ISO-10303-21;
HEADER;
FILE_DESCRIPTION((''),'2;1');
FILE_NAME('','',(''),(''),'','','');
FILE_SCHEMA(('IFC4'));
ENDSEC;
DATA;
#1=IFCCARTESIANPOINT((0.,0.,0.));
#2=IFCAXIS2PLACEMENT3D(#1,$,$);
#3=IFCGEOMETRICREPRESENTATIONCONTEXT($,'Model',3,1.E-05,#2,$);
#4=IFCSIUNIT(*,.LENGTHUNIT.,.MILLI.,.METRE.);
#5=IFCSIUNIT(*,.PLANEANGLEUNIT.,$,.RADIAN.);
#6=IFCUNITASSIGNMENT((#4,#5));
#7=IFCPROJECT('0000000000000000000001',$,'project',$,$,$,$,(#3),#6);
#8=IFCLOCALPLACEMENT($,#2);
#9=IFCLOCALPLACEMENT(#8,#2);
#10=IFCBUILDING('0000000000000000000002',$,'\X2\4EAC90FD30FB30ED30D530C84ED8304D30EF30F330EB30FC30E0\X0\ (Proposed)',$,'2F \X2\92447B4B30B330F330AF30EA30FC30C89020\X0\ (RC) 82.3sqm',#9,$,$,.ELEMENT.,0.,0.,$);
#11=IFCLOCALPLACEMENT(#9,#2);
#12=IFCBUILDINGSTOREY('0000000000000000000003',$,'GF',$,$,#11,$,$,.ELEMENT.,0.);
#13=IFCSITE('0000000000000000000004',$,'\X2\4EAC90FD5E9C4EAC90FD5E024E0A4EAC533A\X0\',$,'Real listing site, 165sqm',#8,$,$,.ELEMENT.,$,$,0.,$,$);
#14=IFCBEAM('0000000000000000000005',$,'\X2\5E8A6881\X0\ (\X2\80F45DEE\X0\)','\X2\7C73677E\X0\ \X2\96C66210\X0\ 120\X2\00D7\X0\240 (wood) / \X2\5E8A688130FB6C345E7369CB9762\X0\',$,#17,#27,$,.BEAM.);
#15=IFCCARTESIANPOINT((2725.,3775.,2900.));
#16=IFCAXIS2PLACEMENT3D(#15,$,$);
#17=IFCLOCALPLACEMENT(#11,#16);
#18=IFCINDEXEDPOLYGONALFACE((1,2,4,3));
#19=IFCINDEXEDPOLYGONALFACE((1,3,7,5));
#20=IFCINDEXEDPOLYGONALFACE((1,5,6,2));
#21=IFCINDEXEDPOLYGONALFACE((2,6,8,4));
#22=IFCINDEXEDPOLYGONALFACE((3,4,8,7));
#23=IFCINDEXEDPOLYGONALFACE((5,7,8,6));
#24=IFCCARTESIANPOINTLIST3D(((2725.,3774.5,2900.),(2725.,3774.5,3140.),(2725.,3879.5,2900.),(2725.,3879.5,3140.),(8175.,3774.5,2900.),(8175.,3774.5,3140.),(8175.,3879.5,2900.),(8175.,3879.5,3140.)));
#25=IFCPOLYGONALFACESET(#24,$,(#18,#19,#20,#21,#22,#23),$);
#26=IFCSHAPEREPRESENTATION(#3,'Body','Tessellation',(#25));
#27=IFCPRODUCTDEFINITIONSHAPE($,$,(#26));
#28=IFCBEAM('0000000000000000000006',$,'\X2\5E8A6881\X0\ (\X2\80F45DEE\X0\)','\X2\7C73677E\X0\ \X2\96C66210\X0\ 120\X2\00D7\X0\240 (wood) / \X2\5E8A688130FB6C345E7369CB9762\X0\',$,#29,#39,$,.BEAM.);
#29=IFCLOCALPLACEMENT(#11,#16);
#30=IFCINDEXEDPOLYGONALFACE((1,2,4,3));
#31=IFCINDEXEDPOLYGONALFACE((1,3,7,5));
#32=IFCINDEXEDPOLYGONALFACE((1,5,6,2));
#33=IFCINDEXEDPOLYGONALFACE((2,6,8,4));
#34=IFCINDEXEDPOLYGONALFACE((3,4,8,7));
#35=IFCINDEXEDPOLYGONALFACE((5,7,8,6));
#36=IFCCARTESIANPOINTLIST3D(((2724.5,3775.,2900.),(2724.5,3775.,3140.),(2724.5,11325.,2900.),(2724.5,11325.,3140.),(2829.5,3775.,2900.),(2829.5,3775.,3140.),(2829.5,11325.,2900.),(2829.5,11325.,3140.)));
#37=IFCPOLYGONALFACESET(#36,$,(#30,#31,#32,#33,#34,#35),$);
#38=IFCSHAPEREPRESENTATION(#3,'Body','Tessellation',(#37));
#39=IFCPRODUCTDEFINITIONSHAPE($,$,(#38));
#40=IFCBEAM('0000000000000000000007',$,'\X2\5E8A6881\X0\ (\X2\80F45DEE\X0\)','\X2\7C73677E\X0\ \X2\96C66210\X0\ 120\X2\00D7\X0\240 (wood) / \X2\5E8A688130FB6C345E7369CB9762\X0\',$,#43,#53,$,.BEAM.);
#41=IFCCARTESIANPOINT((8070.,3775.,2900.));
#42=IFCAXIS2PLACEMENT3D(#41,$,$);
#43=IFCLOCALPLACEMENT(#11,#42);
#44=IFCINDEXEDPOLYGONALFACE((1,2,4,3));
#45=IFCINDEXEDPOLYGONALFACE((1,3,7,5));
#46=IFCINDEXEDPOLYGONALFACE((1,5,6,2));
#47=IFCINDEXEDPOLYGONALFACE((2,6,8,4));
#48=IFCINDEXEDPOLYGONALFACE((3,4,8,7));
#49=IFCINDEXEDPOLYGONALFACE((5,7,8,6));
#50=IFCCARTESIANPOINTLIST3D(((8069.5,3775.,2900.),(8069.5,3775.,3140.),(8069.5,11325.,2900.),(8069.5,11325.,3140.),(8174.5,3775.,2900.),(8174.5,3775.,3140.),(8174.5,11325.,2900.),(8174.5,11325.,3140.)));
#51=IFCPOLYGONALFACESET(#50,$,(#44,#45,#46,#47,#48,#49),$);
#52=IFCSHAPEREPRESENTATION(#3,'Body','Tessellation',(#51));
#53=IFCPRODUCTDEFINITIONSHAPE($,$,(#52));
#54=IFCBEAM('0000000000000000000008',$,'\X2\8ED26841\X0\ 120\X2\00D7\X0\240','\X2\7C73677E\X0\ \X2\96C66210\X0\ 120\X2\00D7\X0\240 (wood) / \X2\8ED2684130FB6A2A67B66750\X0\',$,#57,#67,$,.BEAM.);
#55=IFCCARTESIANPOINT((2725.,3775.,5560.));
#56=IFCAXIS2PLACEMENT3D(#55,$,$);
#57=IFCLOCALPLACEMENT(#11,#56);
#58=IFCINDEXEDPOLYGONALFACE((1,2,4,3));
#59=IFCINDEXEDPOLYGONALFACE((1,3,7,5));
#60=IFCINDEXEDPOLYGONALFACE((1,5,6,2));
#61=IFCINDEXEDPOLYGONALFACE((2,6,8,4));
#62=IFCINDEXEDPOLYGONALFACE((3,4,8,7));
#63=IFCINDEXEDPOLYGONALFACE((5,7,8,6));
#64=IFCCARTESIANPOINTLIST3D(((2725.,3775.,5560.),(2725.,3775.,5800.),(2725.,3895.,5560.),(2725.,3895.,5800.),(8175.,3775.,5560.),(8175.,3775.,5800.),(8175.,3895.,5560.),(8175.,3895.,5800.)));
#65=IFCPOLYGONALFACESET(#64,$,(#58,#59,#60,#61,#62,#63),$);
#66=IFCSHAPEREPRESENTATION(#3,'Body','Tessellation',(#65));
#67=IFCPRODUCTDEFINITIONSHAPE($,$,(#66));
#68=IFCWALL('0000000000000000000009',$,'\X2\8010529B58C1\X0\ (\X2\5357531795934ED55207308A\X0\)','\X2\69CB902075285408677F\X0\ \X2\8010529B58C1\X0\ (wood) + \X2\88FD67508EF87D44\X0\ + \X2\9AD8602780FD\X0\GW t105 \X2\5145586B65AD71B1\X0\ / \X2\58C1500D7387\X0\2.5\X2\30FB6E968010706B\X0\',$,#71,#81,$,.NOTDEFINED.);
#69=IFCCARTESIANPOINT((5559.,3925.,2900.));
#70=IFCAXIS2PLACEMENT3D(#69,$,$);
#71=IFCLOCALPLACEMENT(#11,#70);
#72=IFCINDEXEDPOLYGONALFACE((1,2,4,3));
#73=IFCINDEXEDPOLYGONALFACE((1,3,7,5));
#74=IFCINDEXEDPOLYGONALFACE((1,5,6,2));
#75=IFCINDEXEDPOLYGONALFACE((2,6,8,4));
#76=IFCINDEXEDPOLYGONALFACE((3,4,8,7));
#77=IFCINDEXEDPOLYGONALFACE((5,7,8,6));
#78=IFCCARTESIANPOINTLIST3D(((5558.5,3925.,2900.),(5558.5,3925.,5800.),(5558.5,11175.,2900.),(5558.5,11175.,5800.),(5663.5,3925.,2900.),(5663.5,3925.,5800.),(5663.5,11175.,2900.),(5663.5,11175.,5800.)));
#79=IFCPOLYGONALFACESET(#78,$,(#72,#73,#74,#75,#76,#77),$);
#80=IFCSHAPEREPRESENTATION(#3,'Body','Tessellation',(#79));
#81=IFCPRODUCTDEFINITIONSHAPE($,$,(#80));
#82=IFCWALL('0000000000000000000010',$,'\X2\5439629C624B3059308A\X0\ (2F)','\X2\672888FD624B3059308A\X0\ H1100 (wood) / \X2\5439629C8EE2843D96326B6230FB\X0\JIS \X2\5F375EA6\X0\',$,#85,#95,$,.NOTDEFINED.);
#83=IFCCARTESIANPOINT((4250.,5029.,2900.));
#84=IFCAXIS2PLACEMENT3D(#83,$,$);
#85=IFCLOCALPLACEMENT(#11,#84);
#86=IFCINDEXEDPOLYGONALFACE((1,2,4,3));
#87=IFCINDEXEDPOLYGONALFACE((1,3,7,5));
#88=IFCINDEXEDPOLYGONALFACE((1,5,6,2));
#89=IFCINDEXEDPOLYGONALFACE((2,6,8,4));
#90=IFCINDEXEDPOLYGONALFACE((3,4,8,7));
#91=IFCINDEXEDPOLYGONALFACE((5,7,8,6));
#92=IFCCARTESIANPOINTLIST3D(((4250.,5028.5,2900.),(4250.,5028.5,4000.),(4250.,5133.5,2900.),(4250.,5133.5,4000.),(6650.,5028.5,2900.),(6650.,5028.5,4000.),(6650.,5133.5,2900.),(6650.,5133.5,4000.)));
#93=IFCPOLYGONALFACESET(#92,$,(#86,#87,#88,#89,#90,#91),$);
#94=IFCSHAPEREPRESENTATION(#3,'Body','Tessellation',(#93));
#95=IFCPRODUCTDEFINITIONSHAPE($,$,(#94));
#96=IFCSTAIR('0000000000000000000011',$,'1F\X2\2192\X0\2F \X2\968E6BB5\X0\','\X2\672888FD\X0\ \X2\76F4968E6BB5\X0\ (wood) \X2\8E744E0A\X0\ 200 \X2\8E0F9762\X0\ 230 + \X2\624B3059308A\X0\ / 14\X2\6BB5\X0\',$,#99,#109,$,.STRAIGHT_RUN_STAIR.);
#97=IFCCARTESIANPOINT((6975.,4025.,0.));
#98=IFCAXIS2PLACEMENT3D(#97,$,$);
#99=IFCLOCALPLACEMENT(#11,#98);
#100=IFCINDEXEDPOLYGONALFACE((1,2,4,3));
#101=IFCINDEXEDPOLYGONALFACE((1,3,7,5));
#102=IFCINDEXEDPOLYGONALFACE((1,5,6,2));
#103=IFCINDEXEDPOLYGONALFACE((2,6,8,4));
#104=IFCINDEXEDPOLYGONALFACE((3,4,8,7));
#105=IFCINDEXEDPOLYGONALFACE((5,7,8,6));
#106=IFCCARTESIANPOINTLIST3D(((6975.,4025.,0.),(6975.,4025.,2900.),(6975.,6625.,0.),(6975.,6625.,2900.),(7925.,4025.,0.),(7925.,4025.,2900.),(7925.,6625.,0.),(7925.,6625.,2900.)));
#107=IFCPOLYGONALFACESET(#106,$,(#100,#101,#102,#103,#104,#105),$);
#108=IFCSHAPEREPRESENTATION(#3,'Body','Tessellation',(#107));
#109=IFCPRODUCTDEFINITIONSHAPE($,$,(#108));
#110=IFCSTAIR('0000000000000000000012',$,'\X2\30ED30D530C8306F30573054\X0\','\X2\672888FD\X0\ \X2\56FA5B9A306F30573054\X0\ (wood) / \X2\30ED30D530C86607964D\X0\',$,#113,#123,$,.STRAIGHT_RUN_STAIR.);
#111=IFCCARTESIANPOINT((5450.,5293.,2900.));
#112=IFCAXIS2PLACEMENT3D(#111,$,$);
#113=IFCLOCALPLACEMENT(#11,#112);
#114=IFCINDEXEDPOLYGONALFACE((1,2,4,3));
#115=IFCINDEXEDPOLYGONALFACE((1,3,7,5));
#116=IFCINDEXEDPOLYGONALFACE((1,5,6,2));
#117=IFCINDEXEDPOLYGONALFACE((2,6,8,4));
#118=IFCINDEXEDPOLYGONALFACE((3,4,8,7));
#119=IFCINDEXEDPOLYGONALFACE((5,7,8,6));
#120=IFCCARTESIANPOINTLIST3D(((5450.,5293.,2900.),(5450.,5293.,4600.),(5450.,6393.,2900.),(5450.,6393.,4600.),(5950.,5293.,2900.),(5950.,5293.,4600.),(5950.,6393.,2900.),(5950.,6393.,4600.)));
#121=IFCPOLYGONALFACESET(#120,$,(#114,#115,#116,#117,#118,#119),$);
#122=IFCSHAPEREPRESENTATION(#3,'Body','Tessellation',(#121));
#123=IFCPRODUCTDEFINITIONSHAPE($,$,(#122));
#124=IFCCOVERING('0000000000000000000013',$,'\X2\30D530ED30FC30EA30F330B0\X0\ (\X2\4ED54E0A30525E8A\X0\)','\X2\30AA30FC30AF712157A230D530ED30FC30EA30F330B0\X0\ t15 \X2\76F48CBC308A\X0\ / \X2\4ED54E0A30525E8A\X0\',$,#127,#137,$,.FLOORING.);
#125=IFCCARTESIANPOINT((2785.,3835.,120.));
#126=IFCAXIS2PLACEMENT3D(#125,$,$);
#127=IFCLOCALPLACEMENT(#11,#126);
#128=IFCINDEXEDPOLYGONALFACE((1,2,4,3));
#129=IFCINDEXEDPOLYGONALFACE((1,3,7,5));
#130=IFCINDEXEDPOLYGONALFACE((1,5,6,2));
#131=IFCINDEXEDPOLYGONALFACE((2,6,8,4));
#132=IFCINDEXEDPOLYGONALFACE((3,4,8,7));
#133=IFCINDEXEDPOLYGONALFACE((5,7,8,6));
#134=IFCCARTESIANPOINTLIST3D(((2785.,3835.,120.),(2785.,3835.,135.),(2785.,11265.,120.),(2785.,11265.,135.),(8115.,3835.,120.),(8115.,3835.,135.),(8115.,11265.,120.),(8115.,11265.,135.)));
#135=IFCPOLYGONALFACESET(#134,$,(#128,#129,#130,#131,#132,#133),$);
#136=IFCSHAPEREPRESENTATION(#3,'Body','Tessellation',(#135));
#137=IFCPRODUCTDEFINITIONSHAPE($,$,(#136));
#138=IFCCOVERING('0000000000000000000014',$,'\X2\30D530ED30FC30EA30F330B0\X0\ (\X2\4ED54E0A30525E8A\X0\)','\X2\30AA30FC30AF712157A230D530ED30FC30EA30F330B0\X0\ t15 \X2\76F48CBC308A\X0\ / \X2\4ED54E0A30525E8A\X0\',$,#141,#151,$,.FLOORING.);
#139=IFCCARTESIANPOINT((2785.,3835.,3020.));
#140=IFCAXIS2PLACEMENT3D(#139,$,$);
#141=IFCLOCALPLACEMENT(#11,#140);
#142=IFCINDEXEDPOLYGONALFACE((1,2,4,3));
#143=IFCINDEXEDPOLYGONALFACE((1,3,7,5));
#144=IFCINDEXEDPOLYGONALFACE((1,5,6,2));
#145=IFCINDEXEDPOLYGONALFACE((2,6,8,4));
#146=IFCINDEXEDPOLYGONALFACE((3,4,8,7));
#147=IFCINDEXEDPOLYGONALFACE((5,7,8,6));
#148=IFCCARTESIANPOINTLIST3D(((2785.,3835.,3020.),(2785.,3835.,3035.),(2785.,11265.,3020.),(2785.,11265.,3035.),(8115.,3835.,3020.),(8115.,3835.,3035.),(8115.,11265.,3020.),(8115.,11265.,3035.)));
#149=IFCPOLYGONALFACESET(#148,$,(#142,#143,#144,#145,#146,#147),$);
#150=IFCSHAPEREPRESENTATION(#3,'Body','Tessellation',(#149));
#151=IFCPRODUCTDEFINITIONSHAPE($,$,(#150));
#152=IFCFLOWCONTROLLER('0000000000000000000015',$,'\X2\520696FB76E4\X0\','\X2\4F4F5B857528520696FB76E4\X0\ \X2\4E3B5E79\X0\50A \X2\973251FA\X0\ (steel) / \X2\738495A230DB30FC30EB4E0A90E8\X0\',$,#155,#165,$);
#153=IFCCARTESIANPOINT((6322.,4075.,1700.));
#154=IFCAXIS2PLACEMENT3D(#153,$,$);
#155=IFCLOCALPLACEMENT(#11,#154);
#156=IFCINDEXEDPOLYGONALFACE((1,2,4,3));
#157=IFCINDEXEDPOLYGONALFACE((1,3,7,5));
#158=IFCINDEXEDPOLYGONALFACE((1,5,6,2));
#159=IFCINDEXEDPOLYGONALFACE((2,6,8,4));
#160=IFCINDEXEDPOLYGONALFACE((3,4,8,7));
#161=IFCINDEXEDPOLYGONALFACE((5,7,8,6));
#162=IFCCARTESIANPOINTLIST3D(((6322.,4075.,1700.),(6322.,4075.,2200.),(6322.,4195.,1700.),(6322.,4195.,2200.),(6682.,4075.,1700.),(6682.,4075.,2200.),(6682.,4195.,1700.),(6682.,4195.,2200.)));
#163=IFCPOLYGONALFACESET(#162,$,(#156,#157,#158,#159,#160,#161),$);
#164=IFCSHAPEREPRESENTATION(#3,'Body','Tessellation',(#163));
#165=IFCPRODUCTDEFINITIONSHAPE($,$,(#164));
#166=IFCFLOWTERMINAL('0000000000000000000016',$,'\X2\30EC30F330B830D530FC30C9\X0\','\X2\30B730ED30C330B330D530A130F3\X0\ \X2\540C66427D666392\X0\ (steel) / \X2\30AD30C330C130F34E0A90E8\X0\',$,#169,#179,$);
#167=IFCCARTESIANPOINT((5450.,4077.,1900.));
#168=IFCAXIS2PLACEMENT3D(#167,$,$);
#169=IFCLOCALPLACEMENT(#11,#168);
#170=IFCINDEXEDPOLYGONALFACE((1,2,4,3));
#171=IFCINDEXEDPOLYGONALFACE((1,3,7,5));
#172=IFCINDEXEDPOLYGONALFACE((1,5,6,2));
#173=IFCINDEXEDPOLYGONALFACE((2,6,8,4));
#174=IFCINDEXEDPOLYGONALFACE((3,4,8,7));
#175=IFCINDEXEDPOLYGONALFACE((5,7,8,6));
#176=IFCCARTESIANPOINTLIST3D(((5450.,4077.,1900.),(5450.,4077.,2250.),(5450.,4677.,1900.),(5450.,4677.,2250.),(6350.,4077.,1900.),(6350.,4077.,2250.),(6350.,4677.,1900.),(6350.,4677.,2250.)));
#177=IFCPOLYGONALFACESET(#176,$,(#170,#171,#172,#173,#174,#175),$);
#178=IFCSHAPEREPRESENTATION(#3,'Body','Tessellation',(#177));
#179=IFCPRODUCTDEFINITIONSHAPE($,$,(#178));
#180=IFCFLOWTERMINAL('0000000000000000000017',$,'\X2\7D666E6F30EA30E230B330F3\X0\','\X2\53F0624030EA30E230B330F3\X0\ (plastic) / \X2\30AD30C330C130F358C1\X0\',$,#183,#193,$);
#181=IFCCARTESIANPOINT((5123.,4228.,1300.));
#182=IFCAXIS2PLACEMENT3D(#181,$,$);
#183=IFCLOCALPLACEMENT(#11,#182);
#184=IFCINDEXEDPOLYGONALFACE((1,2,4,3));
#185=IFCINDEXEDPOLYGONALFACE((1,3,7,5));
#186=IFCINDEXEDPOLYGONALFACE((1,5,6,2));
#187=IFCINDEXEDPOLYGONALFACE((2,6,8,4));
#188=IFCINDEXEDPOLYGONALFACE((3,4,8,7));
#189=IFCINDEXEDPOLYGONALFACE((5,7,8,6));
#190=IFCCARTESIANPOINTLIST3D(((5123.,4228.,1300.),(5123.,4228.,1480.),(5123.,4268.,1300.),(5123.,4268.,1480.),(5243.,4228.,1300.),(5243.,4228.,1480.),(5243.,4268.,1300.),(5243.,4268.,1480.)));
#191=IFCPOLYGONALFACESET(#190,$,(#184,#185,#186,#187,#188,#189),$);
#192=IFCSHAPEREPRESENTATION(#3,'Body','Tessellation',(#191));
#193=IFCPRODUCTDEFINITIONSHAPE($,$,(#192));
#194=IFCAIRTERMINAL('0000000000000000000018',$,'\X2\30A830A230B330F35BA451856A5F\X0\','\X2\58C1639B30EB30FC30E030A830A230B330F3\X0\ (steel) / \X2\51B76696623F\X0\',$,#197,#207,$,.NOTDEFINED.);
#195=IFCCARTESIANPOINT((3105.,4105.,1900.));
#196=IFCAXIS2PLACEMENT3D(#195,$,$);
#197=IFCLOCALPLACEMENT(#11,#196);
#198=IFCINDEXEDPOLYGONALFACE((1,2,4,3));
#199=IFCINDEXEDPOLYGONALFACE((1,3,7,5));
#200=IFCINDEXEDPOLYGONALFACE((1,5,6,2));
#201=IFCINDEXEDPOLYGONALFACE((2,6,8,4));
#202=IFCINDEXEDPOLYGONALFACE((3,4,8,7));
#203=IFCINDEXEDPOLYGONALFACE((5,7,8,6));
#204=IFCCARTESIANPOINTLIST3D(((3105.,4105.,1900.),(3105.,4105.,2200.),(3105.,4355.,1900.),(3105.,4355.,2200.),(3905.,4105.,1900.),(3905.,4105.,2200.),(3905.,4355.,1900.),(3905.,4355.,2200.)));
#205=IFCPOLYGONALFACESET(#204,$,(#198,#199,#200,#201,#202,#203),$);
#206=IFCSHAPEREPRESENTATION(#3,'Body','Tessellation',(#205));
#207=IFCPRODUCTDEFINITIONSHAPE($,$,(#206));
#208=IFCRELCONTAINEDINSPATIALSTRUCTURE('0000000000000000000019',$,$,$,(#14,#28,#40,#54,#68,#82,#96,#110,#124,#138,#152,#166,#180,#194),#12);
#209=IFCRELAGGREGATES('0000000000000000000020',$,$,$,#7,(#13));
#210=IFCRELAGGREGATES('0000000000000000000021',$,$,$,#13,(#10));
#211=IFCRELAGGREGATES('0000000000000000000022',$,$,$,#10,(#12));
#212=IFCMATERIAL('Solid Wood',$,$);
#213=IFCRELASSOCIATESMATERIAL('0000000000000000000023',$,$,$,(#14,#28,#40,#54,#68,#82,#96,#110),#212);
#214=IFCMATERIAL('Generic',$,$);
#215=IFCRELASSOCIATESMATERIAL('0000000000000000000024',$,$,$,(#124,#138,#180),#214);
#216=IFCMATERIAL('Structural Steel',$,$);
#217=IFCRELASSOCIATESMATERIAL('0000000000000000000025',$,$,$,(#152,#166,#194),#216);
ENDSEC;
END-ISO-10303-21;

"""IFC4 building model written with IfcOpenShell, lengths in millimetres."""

from ifc_helpers import new_model, si_unit, frame, frame_2d, origin, place, context, project, spatial, rectangle, extrude, material, element, save


model = new_model("IFC4")

# Units and contexts
model_context = context("Model", 3, precision=1e-05, world=origin())
ifc_project = project(units=[si_unit("LENGTHUNIT", "METRE", prefix="MILLI"), si_unit("PLANEANGLEUNIT", "RADIAN")], contexts=[model_context])

# Site, building, storey
site_placement = place(None, origin())
site = spatial("IfcSite", under=ifc_project, at=site_placement, Name="京都府京都市上京区", ObjectType="Real listing site, 165sqm", CompositionType="ELEMENT", RefElevation=0.0)
building_placement = place(site_placement, origin())
building = spatial("IfcBuilding", under=site, at=building_placement, Name="京都・ロフト付きワンルーム (Proposed)", ObjectType="2F 鉄筋コンクリート造 (RC) 82.3sqm", CompositionType="ELEMENT", ElevationOfRefHeight=0.0, ElevationOfTerrain=0.0)
storey_placement = place(building_placement, origin())
storey = spatial("IfcBuildingStorey", under=building, at=storey_placement, Name="GF", CompositionType="ELEMENT", Elevation=0.0)

# Beams
ifc_material_1 = material(Name="Solid Wood")
beam_1_placement = place(storey_placement, frame((2725.0, 3775.0, 2900.0)))
element("IfcBeam", 1, at=beam_1_placement, inside=storey, material=ifc_material_1, Name="床梁 (胴差)", Description="米松 集成 120×240 (wood) / 床梁・水平構面", PredefinedType="BEAM", context=model_context, shape_type="SweptSolid", body=[
    extrude(rectangle(XDim=5450.0, YDim=105.0, at=frame_2d((2725.0, 52.0))), frame((2725.0, 3775.0, 2900.0)), (0.0, 0.0, 1.0), 240.0),
])
beam_2_placement = place(storey_placement, frame((2725.0, 3775.0, 2900.0)))
element("IfcBeam", 2, at=beam_2_placement, inside=storey, material=ifc_material_1, Name="床梁 (胴差)", Description="米松 集成 120×240 (wood) / 床梁・水平構面", PredefinedType="BEAM", context=model_context, shape_type="SweptSolid", body=[
    extrude(rectangle(XDim=105.0, YDim=7550.0, at=frame_2d((52.0, 3775.0))), frame((2725.0, 3775.0, 2900.0)), (0.0, 0.0, 1.0), 240.0),
])
beam_3_placement = place(storey_placement, frame((8070.0, 3775.0, 2900.0)))
element("IfcBeam", 3, at=beam_3_placement, inside=storey, material=ifc_material_1, Name="床梁 (胴差)", Description="米松 集成 120×240 (wood) / 床梁・水平構面", PredefinedType="BEAM", context=model_context, shape_type="SweptSolid", body=[
    extrude(rectangle(XDim=105.0, YDim=7550.0, at=frame_2d((52.0, 3775.0))), frame((8070.0, 3775.0, 2900.0)), (0.0, 0.0, 1.0), 240.0),
])
beam_4_placement = place(storey_placement, frame((2725.0, 3775.0, 5560.0)))
element("IfcBeam", 4, at=beam_4_placement, inside=storey, material=ifc_material_1, Name="軒桁 120×240", Description="米松 集成 120×240 (wood) / 軒桁・横架材", PredefinedType="BEAM", context=model_context, shape_type="SweptSolid", body=[
    extrude(rectangle(XDim=5450.0, YDim=120.0, at=frame_2d((2725.0, 60.0))), frame((2725.0, 3775.0, 5560.0)), (0.0, 0.0, 1.0), 240.0),
])

# Walls
wall_1_placement = place(storey_placement, frame((5559.0, 3925.0, 2900.0)))
element("IfcWall", 5, at=wall_1_placement, inside=storey, material=ifc_material_1, Name="耐力壁 (南北間仕切り)", Description="構造用合板 耐力壁 (wood) + 製材軸組 + 高性能GW t105 充填断熱 / 壁倍率2.5・準耐火", PredefinedType="NOTDEFINED", context=model_context, shape_type="SweptSolid", body=[
    extrude(rectangle(XDim=105.0, YDim=7250.0, at=frame_2d((52.0, 3625.0))), frame((5559.0, 3925.0, 2900.0)), (0.0, 0.0, 1.0), 2900.0),
])
wall_2_placement = place(storey_placement, frame((4250.0, 5029.0, 2900.0)))
element("IfcWall", 6, at=wall_2_placement, inside=storey, material=ifc_material_1, Name="吹抜手すり (2F)", Description="木製手すり H1100 (wood) / 吹抜転落防止・JIS 強度", PredefinedType="NOTDEFINED", context=model_context, shape_type="SweptSolid", body=[
    extrude(rectangle(XDim=2400.0, YDim=105.0, at=frame_2d((1200.0, 52.0))), frame((4250.0, 5029.0, 2900.0)), (0.0, 0.0, 1.0), 1100.0),
])

# Stairs
stair_1_placement = place(storey_placement, frame((6975.0, 4025.0, 0.0)))
element("IfcStair", 7, at=stair_1_placement, inside=storey, material=ifc_material_1, Name="1F→2F 階段", Description="木製 直階段 (wood) 蹴上 200 踏面 230 + 手すり / 14段", PredefinedType="STRAIGHT_RUN_STAIR", context=model_context, shape_type="SweptSolid", body=[
    extrude(rectangle(XDim=950.0, YDim=2600.0, at=frame_2d((475.0, 1300.0))), frame((6975.0, 4025.0, 0.0)), (0.0, 0.0, 1.0), 2900.0),
])
stair_2_placement = place(storey_placement, frame((5450.0, 5293.0, 2900.0)))
element("IfcStair", 8, at=stair_2_placement, inside=storey, material=ifc_material_1, Name="ロフトはしご", Description="木製 固定はしご (wood) / ロフト昇降", PredefinedType="STRAIGHT_RUN_STAIR", context=model_context, shape_type="SweptSolid", body=[
    extrude(rectangle(XDim=500.0, YDim=1100.0, at=frame_2d((250.0, 550.0))), frame((5450.0, 5293.0, 2900.0)), (0.0, 0.0, 1.0), 1700.0),
])

# Coverings
ifc_material_2 = material(Name="Generic")
covering_1_placement = place(storey_placement, frame((2785.0, 3835.0, 120.0)))
element("IfcCovering", 9, at=covering_1_placement, inside=storey, material=ifc_material_2, Name="フローリング (仕上げ床)", Description="オーク無垢フローリング t15 直貼り / 仕上げ床", PredefinedType="FLOORING", context=model_context, shape_type="SweptSolid", body=[
    extrude(rectangle(XDim=5330.0, YDim=7430.0, at=frame_2d((2665.0, 3715.0))), frame((2785.0, 3835.0, 120.0)), (0.0, 0.0, 1.0), 15.0),
])
covering_2_placement = place(storey_placement, frame((2785.0, 3835.0, 3020.0)))
element("IfcCovering", 10, at=covering_2_placement, inside=storey, material=ifc_material_2, Name="フローリング (仕上げ床)", Description="オーク無垢フローリング t15 直貼り / 仕上げ床", PredefinedType="FLOORING", context=model_context, shape_type="SweptSolid", body=[
    extrude(rectangle(XDim=5330.0, YDim=7430.0, at=frame_2d((2665.0, 3715.0))), frame((2785.0, 3835.0, 3020.0)), (0.0, 0.0, 1.0), 15.0),
])

# Flow controller
ifc_material_3 = material(Name="Structural Steel")
flow_controller_placement = place(storey_placement, frame((6322.0, 4075.0, 1700.0)))
element("IfcFlowController", 11, at=flow_controller_placement, inside=storey, material=ifc_material_3, Name="分電盤", Description="住宅用分電盤 主幹50A 露出 (steel) / 玄関ホール上部", context=model_context, shape_type="SweptSolid", body=[
    extrude(rectangle(XDim=360.0, YDim=120.0, at=frame_2d((180.0, 60.0))), frame((6322.0, 4075.0, 1700.0)), (0.0, 0.0, 1.0), 500.0),
])

# Flow terminals
flow_terminal_1_placement = place(storey_placement, frame((5450.0, 4077.0, 1900.0)))
element("IfcFlowTerminal", 12, at=flow_terminal_1_placement, inside=storey, material=ifc_material_3, Name="レンジフード", Description="シロッコファン 同時給排 (steel) / キッチン上部", context=model_context, shape_type="SweptSolid", body=[
    extrude(rectangle(XDim=900.0, YDim=600.0, at=frame_2d((450.0, 300.0))), frame((5450.0, 4077.0, 1900.0)), (0.0, 0.0, 1.0), 350.0),
])
flow_terminal_2_placement = place(storey_placement, frame((5123.0, 4228.0, 1300.0)))
element("IfcFlowTerminal", 13, at=flow_terminal_2_placement, inside=storey, material=ifc_material_2, Name="給湯リモコン", Description="台所リモコン (plastic) / キッチン壁", context=model_context, shape_type="SweptSolid", body=[
    extrude(rectangle(XDim=120.0, YDim=40.0, at=frame_2d((60.0, 20.0))), frame((5123.0, 4228.0, 1300.0)), (0.0, 0.0, 1.0), 180.0),
])

# Air terminal
air_terminal_1_placement = place(storey_placement, frame((3105.0, 4105.0, 1900.0)))
element("IfcAirTerminal", 14, at=air_terminal_1_placement, inside=storey, material=ifc_material_3, Name="エアコン室内機", Description="壁掛ルームエアコン (steel) / 冷暖房", PredefinedType="NOTDEFINED", context=model_context, shape_type="SweptSolid", body=[
    extrude(rectangle(XDim=800.0, YDim=250.0, at=frame_2d((400.0, 125.0))), frame((3105.0, 4105.0, 1900.0)), (0.0, 0.0, 1.0), 300.0),
])

save(model, "model.ifc")
